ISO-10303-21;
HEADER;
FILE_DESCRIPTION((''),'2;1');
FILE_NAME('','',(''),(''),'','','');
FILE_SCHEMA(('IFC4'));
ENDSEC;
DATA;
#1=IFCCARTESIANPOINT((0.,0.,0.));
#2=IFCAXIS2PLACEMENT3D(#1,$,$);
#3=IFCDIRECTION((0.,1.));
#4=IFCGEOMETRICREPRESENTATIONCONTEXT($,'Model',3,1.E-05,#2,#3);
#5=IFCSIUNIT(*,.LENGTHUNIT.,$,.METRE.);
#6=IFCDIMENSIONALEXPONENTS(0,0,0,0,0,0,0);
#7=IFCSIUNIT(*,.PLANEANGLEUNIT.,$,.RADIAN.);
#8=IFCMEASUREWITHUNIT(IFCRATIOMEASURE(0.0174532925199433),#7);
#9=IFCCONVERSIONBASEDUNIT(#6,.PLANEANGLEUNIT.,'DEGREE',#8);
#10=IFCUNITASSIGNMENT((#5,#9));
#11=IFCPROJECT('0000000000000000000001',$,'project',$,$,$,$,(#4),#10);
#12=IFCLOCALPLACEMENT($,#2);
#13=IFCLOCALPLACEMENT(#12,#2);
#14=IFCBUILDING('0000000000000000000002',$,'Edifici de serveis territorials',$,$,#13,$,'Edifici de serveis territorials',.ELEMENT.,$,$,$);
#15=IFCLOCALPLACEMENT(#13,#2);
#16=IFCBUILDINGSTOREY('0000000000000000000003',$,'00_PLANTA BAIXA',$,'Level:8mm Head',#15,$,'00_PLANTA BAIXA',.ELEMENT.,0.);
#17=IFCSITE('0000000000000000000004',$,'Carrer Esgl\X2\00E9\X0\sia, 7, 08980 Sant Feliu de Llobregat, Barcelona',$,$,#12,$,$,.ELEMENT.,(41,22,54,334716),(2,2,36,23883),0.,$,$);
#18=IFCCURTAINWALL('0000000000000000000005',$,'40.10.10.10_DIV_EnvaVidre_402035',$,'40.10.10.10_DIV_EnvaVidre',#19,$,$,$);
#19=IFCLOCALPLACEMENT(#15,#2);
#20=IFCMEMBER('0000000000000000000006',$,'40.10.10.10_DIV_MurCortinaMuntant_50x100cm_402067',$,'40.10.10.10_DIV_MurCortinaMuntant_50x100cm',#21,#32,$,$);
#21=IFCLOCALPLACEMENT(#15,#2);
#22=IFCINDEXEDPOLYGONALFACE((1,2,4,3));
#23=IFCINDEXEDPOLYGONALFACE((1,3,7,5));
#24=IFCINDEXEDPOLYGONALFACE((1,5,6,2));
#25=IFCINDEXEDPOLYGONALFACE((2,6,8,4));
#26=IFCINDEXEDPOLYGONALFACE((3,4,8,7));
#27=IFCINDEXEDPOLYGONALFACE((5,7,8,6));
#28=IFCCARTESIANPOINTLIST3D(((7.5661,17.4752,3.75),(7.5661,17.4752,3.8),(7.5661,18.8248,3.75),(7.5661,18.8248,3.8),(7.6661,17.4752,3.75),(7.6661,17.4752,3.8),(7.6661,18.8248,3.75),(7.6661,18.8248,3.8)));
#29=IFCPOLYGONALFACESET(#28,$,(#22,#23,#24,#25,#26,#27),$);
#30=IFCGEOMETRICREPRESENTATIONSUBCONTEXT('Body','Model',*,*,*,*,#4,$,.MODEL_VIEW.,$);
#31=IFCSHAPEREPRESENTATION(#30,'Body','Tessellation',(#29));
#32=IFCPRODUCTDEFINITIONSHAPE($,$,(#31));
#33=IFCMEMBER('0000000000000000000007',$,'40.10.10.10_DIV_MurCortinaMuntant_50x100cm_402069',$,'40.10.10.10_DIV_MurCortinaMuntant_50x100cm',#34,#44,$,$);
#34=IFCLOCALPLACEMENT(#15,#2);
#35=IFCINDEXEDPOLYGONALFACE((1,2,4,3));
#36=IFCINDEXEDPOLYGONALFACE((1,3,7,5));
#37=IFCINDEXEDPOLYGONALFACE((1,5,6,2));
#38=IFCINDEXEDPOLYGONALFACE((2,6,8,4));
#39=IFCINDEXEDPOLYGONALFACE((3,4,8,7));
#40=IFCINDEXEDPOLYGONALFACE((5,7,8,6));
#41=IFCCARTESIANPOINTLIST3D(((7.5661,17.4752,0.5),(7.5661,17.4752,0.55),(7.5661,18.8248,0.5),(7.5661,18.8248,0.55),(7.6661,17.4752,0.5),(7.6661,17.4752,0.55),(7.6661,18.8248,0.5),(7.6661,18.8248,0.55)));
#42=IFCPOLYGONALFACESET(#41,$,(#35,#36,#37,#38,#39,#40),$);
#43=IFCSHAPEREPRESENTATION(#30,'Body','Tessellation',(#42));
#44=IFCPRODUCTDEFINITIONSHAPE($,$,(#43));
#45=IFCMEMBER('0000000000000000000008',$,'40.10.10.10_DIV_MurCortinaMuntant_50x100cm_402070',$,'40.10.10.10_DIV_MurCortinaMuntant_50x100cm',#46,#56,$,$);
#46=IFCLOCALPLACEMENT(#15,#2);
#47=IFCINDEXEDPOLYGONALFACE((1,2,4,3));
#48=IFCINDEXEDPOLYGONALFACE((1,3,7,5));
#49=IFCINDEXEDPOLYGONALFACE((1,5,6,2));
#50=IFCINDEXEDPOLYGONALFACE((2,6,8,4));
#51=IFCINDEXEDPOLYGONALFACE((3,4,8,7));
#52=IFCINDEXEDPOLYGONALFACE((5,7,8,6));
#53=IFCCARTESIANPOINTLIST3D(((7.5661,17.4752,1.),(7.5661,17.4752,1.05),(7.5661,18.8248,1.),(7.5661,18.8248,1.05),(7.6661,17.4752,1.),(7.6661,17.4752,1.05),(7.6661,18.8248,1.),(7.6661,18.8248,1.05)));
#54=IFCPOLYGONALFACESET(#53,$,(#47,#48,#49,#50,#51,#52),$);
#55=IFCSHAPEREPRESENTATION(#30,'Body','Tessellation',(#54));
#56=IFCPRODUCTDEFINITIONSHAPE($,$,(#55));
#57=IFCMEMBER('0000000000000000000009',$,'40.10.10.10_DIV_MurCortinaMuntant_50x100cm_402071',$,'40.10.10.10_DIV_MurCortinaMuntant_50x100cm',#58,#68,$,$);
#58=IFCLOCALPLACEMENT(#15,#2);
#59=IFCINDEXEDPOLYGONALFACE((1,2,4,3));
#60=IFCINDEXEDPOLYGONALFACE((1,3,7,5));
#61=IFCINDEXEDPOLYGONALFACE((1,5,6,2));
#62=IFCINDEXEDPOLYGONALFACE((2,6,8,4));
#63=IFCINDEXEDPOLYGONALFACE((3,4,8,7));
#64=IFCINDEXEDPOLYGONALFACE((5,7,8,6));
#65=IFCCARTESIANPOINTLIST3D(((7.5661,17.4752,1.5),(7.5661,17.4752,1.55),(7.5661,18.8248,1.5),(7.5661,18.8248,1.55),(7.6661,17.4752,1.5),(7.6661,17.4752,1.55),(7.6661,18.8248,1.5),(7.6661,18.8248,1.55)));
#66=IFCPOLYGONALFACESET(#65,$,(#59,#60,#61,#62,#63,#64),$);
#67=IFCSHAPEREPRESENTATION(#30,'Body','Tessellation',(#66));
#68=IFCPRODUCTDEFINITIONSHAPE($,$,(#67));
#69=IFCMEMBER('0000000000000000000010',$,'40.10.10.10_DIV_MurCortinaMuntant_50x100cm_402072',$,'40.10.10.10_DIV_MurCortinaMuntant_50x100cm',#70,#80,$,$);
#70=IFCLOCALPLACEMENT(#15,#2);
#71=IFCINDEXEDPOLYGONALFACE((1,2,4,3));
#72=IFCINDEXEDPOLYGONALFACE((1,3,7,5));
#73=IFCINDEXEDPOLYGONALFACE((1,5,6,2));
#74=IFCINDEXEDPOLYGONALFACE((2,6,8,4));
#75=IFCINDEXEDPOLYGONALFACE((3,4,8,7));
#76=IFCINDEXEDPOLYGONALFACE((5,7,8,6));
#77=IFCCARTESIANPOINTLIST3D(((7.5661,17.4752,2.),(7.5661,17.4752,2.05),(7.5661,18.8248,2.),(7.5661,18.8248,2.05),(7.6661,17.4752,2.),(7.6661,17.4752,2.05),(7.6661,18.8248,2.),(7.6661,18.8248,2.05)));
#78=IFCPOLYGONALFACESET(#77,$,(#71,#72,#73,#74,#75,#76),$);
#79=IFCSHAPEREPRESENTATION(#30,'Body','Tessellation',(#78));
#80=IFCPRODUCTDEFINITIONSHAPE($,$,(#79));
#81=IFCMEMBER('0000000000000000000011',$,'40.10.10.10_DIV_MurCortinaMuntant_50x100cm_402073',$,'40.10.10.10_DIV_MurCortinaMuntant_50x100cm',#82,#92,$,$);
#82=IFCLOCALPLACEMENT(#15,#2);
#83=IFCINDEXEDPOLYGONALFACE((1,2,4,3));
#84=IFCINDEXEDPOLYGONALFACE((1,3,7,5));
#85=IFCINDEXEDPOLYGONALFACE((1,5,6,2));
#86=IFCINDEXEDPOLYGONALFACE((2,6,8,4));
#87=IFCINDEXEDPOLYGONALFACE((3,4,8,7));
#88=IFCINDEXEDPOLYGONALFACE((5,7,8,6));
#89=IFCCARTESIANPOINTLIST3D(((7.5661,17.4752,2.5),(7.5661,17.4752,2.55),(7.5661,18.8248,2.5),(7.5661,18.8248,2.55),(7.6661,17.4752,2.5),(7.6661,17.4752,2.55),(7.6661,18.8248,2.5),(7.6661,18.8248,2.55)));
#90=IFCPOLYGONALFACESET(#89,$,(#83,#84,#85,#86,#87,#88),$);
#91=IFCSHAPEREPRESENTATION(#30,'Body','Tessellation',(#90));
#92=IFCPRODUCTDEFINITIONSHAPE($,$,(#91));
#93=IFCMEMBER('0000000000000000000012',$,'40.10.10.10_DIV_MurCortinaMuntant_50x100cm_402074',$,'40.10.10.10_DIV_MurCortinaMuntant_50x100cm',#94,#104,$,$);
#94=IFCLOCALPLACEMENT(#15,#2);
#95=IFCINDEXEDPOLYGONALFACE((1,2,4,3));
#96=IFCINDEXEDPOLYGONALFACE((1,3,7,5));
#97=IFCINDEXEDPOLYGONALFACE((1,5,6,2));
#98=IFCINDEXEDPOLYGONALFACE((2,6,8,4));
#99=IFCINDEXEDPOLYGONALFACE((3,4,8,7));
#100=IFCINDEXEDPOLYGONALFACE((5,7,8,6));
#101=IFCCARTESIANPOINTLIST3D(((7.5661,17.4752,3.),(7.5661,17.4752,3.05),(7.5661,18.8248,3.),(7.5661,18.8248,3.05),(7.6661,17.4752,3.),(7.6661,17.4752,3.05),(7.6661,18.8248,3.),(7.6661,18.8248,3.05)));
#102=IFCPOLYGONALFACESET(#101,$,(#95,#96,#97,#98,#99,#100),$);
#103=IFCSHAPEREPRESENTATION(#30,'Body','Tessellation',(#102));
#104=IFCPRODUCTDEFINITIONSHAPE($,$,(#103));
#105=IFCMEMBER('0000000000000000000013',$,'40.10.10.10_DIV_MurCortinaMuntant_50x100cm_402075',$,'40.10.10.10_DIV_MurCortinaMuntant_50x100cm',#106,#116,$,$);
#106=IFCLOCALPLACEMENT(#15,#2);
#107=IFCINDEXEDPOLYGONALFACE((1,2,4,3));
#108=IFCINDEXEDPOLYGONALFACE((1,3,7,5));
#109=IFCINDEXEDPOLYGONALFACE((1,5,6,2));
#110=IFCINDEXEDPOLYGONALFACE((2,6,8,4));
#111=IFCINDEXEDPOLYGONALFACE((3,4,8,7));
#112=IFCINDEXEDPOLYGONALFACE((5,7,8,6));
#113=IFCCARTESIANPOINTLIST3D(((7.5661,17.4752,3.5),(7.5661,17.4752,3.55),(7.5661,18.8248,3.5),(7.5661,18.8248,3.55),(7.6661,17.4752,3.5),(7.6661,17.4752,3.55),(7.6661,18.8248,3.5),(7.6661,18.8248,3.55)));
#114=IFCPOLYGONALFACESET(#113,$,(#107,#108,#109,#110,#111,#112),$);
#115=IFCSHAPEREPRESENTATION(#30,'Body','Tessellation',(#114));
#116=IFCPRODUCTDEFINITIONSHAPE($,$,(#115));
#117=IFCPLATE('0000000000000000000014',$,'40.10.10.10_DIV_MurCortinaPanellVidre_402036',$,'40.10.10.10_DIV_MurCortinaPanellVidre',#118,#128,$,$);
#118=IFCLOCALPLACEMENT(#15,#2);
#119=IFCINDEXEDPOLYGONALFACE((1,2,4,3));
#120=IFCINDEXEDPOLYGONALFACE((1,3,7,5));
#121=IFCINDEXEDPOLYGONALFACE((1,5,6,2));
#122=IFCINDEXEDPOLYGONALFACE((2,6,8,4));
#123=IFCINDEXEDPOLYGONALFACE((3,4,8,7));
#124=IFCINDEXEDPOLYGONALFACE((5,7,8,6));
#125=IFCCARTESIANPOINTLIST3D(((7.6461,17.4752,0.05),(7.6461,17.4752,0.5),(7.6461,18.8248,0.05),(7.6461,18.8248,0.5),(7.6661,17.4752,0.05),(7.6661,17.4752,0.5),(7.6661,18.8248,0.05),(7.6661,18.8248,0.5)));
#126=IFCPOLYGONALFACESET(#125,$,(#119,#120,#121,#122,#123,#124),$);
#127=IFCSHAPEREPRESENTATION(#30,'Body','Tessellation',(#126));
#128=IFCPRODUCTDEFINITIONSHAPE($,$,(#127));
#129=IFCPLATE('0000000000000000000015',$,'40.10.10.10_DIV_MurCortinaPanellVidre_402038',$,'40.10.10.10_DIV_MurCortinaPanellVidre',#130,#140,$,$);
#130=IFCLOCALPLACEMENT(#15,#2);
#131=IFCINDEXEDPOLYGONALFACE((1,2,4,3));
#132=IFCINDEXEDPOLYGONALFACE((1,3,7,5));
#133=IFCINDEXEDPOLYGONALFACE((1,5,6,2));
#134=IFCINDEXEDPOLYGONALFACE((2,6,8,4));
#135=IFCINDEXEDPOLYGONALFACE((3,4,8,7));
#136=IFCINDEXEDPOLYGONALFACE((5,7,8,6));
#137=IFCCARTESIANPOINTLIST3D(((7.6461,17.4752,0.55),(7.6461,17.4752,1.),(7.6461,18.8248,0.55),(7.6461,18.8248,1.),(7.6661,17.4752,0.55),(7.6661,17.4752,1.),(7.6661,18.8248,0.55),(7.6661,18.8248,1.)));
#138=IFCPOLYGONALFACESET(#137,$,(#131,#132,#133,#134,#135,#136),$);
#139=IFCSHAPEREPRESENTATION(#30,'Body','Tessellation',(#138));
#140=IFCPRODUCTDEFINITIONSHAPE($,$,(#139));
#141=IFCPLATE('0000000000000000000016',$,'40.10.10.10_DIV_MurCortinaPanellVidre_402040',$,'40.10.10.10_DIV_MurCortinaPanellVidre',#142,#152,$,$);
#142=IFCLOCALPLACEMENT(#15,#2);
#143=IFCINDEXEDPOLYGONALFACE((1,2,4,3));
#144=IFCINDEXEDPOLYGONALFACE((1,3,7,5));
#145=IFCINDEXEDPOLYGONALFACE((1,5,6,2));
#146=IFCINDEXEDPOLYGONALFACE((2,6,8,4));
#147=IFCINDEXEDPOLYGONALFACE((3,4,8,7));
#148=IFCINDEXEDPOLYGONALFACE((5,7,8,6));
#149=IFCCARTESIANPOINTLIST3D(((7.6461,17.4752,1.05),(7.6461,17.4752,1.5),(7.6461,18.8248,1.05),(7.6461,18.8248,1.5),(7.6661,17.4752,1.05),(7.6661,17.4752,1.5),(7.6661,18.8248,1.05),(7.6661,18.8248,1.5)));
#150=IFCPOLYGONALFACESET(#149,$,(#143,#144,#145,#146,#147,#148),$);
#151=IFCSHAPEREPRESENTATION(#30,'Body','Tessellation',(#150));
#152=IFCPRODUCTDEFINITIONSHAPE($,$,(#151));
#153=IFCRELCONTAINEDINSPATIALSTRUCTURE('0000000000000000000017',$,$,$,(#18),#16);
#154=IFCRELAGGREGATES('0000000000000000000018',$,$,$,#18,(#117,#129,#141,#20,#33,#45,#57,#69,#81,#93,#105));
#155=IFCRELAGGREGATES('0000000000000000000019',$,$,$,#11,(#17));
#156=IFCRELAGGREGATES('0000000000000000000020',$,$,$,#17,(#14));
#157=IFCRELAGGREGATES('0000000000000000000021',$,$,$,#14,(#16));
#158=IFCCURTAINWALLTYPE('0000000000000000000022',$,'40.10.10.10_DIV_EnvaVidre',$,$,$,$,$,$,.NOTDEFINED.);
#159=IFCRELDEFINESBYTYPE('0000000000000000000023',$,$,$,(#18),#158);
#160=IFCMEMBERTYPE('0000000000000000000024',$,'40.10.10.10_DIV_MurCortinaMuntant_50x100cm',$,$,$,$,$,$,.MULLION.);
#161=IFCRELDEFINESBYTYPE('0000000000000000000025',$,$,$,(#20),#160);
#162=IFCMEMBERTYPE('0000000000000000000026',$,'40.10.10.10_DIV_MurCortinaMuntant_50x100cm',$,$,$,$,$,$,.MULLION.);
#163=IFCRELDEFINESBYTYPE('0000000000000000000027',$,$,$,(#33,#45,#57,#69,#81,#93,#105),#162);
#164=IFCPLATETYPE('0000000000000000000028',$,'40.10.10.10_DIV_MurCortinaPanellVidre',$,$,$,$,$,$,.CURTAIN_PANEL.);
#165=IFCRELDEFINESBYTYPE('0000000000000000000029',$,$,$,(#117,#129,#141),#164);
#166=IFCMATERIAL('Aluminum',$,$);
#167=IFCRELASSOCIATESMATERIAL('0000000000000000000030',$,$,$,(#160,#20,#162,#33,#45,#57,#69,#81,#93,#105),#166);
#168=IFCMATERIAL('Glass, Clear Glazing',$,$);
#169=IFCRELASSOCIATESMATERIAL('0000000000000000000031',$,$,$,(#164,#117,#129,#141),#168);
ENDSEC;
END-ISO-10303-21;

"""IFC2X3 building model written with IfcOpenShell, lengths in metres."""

from ifc_helpers import new_model, entity, si_unit, converted_unit, direction, frame, frame_2d, origin, origin_2d_with_axis, place, context, subcontext, project, spatial, rectangle, extrude, source, transform, mapped, material, type_object, type_shapes, element, aggregate, save


model = new_model("IFC2X3")

# Units and contexts
model_context = context("Model", 3, precision=1e-05, world=origin(), true_north=direction((0.0, 1.0)))
body_context = subcontext(model_context, "Body", "Model", "MODEL_VIEW")
ifc_project = project(units=[si_unit("LENGTHUNIT", "METRE"), converted_unit("PLANEANGLEUNIT", "DEGREE", entity("IfcRatioMeasure", 0.0174532925199433), si_unit("PLANEANGLEUNIT", "RADIAN"), dimensions=[0, 0, 0, 0, 0, 0, 0])], contexts=[model_context])

# Site, building, storey
site_placement = place(None, origin())
site = spatial("IfcSite", under=ifc_project, at=site_placement, Name="Carrer Església, 7, 08980 Sant Feliu de Llobregat, Barcelona", CompositionType="ELEMENT", RefLatitude=(41, 22, 54, 334716), RefLongitude=(2, 2, 36, 23883), RefElevation=0.0)
building_placement = place(site_placement, origin())
building = spatial("IfcBuilding", under=site, at=building_placement, Name="Edifici de serveis territorials", LongName="Edifici de serveis territorials", CompositionType="ELEMENT")
storey_placement = place(building_placement, origin())
storey = spatial("IfcBuildingStorey", under=building, at=storey_placement, Name="00_PLANTA BAIXA", ObjectType="Level:8mm Head", LongName="00_PLANTA BAIXA", CompositionType="ELEMENT", Elevation=0.0)

# Curtain wall
curtain_wall_type = type_object("IfcCurtainWallType", Name="40.10.10.10_DIV_EnvaVidre", PredefinedType="NOTDEFINED")
curtain_wall_1_placement = place(storey_placement, origin())
curtain_wall_1 = element("IfcCurtainWall", 1, at=curtain_wall_1_placement, inside=storey, type_object=curtain_wall_type, Name="40.10.10.10_DIV_EnvaVidre_402035", ObjectType="40.10.10.10_DIV_EnvaVidre")
ifc_material_1 = material(Name="Aluminum")

# Members
member_type_1 = type_object("IfcMemberType", Name="40.10.10.10_DIV_MurCortinaMuntant_50x100cm", PredefinedType="MULLION", material=ifc_material_1)
shared_shape_1 = source(origin(), body_context, "Body", "SweptSolid", [
    extrude(rectangle(XDim=0.1, YDim=0.05, at=origin_2d_with_axis()), frame((-0.025, 0.0, -1.3496), z_axis=(0.0, 0.0, 1.0), x_axis=(0.0, -1.0, 0.0)), (0.0, 0.0, 1.0), 1.3496),
])
type_shapes(member_type_1, [shared_shape_1])
member_1_placement = place(storey_placement, frame((7.6161, 17.4752, 3.8), z_axis=(0.0, -1.0, 0.0), x_axis=(0.0, 0.0, 1.0)))
member_1 = element("IfcMember", 2, at=member_1_placement, type_object=member_type_1, material=ifc_material_1, Name="40.10.10.10_DIV_MurCortinaMuntant_50x100cm_402067", ObjectType="40.10.10.10_DIV_MurCortinaMuntant_50x100cm", context=body_context, shape_type="MappedRepresentation", body=[
    mapped(shared_shape_1, transform((0.0, 0.0, 0.0), scale=1.0)),
])
member_type_2 = type_object("IfcMemberType", Name="40.10.10.10_DIV_MurCortinaMuntant_50x100cm", PredefinedType="MULLION", material=ifc_material_1)
shared_shape_2 = source(origin(), body_context, "Body", "SweptSolid", [
    extrude(rectangle(XDim=0.1, YDim=0.05, at=origin_2d_with_axis()), frame((0.0, 0.0, -1.3496), z_axis=(0.0, 0.0, 1.0), x_axis=(0.0, -1.0, 0.0)), (0.0, 0.0, 1.0), 1.3496),
])
type_shapes(member_type_2, [shared_shape_2])
member_2_placement = place(storey_placement, frame((7.6161, 17.4752, 0.525), z_axis=(0.0, -1.0, 0.0), x_axis=(0.0, 0.0, 1.0)))
member_2 = element("IfcMember", 3, at=member_2_placement, type_object=member_type_2, material=ifc_material_1, Name="40.10.10.10_DIV_MurCortinaMuntant_50x100cm_402069", ObjectType="40.10.10.10_DIV_MurCortinaMuntant_50x100cm", context=body_context, shape_type="MappedRepresentation", body=[
    mapped(shared_shape_2, transform((0.0, 0.0, 0.0), scale=1.0)),
])
member_3_placement = place(storey_placement, frame((7.6161, 17.4752, 1.025), z_axis=(0.0, -1.0, 0.0), x_axis=(0.0, 0.0, 1.0)))
member_3 = element("IfcMember", 4, at=member_3_placement, type_object=member_type_2, material=ifc_material_1, Name="40.10.10.10_DIV_MurCortinaMuntant_50x100cm_402070", ObjectType="40.10.10.10_DIV_MurCortinaMuntant_50x100cm", context=body_context, shape_type="MappedRepresentation", body=[
    mapped(shared_shape_2, transform((0.0, 0.0, 0.0), scale=1.0)),
])
member_4_placement = place(storey_placement, frame((7.6161, 17.4752, 1.525), z_axis=(0.0, -1.0, 0.0), x_axis=(0.0, 0.0, 1.0)))
member_4 = element("IfcMember", 5, at=member_4_placement, type_object=member_type_2, material=ifc_material_1, Name="40.10.10.10_DIV_MurCortinaMuntant_50x100cm_402071", ObjectType="40.10.10.10_DIV_MurCortinaMuntant_50x100cm", context=body_context, shape_type="MappedRepresentation", body=[
    mapped(shared_shape_2, transform((0.0, 0.0, 0.0), scale=1.0)),
])
member_5_placement = place(storey_placement, frame((7.6161, 17.4752, 2.025), z_axis=(0.0, -1.0, 0.0), x_axis=(0.0, 0.0, 1.0)))
member_5 = element("IfcMember", 6, at=member_5_placement, type_object=member_type_2, material=ifc_material_1, Name="40.10.10.10_DIV_MurCortinaMuntant_50x100cm_402072", ObjectType="40.10.10.10_DIV_MurCortinaMuntant_50x100cm", context=body_context, shape_type="MappedRepresentation", body=[
    mapped(shared_shape_2, transform((0.0, 0.0, 0.0), scale=1.0)),
])
member_6_placement = place(storey_placement, frame((7.6161, 17.4752, 2.525), z_axis=(0.0, -1.0, 0.0), x_axis=(0.0, 0.0, 1.0)))
member_6 = element("IfcMember", 7, at=member_6_placement, type_object=member_type_2, material=ifc_material_1, Name="40.10.10.10_DIV_MurCortinaMuntant_50x100cm_402073", ObjectType="40.10.10.10_DIV_MurCortinaMuntant_50x100cm", context=body_context, shape_type="MappedRepresentation", body=[
    mapped(shared_shape_2, transform((0.0, 0.0, 0.0), scale=1.0)),
])
member_7_placement = place(storey_placement, frame((7.6161, 17.4752, 3.025), z_axis=(0.0, -1.0, 0.0), x_axis=(0.0, 0.0, 1.0)))
member_7 = element("IfcMember", 8, at=member_7_placement, type_object=member_type_2, material=ifc_material_1, Name="40.10.10.10_DIV_MurCortinaMuntant_50x100cm_402074", ObjectType="40.10.10.10_DIV_MurCortinaMuntant_50x100cm", context=body_context, shape_type="MappedRepresentation", body=[
    mapped(shared_shape_2, transform((0.0, 0.0, 0.0), scale=1.0)),
])
member_8_placement = place(storey_placement, frame((7.6161, 17.4752, 3.525), z_axis=(0.0, -1.0, 0.0), x_axis=(0.0, 0.0, 1.0)))
member_8 = element("IfcMember", 9, at=member_8_placement, type_object=member_type_2, material=ifc_material_1, Name="40.10.10.10_DIV_MurCortinaMuntant_50x100cm_402075", ObjectType="40.10.10.10_DIV_MurCortinaMuntant_50x100cm", context=body_context, shape_type="MappedRepresentation", body=[
    mapped(shared_shape_2, transform((0.0, 0.0, 0.0), scale=1.0)),
])

# Plates
ifc_material_2 = material(Name="Glass, Clear Glazing")
plate_type = type_object("IfcPlateType", Name="40.10.10.10_DIV_MurCortinaPanellVidre", PredefinedType="CURTAIN_PANEL", material=ifc_material_2)
shared_shape_3 = source(origin(), body_context, "Body", "SweptSolid", [
    extrude(rectangle(XDim=0.02, YDim=1.3496, at=frame_2d((0.0, 0.0), x_axis=(1.0, 0.0))), frame((0.6748, 0.01, 0.0), z_axis=(0.0, 0.0, 1.0), x_axis=(0.0, 1.0, 0.0)), (0.0, 0.0, 1.0), 0.45),
])
type_shapes(plate_type, [shared_shape_3])
plate_1_placement = place(curtain_wall_1_placement, frame((7.6461, 18.8248, 0.05), z_axis=(0.0, 0.0, 1.0), x_axis=(0.0, -1.0, 0.0)))
plate_1 = element("IfcPlate", 10, at=plate_1_placement, type_object=plate_type, material=ifc_material_2, Name="40.10.10.10_DIV_MurCortinaPanellVidre_402036", ObjectType="40.10.10.10_DIV_MurCortinaPanellVidre", context=body_context, shape_type="MappedRepresentation", body=[
    mapped(shared_shape_3, transform((0.0, 0.0, 0.0), scale=1.0)),
])
plate_2_placement = place(curtain_wall_1_placement, frame((7.6461, 18.8248, 0.55), z_axis=(0.0, 0.0, 1.0), x_axis=(0.0, -1.0, 0.0)))
plate_2 = element("IfcPlate", 11, at=plate_2_placement, type_object=plate_type, material=ifc_material_2, Name="40.10.10.10_DIV_MurCortinaPanellVidre_402038", ObjectType="40.10.10.10_DIV_MurCortinaPanellVidre", context=body_context, shape_type="MappedRepresentation", body=[
    mapped(shared_shape_3, transform((0.0, 0.0, 0.0), scale=1.0)),
])
plate_3_placement = place(curtain_wall_1_placement, frame((7.6461, 18.8248, 1.05), z_axis=(0.0, 0.0, 1.0), x_axis=(0.0, -1.0, 0.0)))
plate_3 = element("IfcPlate", 12, at=plate_3_placement, type_object=plate_type, material=ifc_material_2, Name="40.10.10.10_DIV_MurCortinaPanellVidre_402040", ObjectType="40.10.10.10_DIV_MurCortinaPanellVidre", context=body_context, shape_type="MappedRepresentation", body=[
    mapped(shared_shape_3, transform((0.0, 0.0, 0.0), scale=1.0)),
])
aggregate(curtain_wall_1, [plate_1, plate_2, plate_3, member_1, member_2, member_3, member_4, member_5, member_6, member_7, member_8])

save(model, "model.ifc")
